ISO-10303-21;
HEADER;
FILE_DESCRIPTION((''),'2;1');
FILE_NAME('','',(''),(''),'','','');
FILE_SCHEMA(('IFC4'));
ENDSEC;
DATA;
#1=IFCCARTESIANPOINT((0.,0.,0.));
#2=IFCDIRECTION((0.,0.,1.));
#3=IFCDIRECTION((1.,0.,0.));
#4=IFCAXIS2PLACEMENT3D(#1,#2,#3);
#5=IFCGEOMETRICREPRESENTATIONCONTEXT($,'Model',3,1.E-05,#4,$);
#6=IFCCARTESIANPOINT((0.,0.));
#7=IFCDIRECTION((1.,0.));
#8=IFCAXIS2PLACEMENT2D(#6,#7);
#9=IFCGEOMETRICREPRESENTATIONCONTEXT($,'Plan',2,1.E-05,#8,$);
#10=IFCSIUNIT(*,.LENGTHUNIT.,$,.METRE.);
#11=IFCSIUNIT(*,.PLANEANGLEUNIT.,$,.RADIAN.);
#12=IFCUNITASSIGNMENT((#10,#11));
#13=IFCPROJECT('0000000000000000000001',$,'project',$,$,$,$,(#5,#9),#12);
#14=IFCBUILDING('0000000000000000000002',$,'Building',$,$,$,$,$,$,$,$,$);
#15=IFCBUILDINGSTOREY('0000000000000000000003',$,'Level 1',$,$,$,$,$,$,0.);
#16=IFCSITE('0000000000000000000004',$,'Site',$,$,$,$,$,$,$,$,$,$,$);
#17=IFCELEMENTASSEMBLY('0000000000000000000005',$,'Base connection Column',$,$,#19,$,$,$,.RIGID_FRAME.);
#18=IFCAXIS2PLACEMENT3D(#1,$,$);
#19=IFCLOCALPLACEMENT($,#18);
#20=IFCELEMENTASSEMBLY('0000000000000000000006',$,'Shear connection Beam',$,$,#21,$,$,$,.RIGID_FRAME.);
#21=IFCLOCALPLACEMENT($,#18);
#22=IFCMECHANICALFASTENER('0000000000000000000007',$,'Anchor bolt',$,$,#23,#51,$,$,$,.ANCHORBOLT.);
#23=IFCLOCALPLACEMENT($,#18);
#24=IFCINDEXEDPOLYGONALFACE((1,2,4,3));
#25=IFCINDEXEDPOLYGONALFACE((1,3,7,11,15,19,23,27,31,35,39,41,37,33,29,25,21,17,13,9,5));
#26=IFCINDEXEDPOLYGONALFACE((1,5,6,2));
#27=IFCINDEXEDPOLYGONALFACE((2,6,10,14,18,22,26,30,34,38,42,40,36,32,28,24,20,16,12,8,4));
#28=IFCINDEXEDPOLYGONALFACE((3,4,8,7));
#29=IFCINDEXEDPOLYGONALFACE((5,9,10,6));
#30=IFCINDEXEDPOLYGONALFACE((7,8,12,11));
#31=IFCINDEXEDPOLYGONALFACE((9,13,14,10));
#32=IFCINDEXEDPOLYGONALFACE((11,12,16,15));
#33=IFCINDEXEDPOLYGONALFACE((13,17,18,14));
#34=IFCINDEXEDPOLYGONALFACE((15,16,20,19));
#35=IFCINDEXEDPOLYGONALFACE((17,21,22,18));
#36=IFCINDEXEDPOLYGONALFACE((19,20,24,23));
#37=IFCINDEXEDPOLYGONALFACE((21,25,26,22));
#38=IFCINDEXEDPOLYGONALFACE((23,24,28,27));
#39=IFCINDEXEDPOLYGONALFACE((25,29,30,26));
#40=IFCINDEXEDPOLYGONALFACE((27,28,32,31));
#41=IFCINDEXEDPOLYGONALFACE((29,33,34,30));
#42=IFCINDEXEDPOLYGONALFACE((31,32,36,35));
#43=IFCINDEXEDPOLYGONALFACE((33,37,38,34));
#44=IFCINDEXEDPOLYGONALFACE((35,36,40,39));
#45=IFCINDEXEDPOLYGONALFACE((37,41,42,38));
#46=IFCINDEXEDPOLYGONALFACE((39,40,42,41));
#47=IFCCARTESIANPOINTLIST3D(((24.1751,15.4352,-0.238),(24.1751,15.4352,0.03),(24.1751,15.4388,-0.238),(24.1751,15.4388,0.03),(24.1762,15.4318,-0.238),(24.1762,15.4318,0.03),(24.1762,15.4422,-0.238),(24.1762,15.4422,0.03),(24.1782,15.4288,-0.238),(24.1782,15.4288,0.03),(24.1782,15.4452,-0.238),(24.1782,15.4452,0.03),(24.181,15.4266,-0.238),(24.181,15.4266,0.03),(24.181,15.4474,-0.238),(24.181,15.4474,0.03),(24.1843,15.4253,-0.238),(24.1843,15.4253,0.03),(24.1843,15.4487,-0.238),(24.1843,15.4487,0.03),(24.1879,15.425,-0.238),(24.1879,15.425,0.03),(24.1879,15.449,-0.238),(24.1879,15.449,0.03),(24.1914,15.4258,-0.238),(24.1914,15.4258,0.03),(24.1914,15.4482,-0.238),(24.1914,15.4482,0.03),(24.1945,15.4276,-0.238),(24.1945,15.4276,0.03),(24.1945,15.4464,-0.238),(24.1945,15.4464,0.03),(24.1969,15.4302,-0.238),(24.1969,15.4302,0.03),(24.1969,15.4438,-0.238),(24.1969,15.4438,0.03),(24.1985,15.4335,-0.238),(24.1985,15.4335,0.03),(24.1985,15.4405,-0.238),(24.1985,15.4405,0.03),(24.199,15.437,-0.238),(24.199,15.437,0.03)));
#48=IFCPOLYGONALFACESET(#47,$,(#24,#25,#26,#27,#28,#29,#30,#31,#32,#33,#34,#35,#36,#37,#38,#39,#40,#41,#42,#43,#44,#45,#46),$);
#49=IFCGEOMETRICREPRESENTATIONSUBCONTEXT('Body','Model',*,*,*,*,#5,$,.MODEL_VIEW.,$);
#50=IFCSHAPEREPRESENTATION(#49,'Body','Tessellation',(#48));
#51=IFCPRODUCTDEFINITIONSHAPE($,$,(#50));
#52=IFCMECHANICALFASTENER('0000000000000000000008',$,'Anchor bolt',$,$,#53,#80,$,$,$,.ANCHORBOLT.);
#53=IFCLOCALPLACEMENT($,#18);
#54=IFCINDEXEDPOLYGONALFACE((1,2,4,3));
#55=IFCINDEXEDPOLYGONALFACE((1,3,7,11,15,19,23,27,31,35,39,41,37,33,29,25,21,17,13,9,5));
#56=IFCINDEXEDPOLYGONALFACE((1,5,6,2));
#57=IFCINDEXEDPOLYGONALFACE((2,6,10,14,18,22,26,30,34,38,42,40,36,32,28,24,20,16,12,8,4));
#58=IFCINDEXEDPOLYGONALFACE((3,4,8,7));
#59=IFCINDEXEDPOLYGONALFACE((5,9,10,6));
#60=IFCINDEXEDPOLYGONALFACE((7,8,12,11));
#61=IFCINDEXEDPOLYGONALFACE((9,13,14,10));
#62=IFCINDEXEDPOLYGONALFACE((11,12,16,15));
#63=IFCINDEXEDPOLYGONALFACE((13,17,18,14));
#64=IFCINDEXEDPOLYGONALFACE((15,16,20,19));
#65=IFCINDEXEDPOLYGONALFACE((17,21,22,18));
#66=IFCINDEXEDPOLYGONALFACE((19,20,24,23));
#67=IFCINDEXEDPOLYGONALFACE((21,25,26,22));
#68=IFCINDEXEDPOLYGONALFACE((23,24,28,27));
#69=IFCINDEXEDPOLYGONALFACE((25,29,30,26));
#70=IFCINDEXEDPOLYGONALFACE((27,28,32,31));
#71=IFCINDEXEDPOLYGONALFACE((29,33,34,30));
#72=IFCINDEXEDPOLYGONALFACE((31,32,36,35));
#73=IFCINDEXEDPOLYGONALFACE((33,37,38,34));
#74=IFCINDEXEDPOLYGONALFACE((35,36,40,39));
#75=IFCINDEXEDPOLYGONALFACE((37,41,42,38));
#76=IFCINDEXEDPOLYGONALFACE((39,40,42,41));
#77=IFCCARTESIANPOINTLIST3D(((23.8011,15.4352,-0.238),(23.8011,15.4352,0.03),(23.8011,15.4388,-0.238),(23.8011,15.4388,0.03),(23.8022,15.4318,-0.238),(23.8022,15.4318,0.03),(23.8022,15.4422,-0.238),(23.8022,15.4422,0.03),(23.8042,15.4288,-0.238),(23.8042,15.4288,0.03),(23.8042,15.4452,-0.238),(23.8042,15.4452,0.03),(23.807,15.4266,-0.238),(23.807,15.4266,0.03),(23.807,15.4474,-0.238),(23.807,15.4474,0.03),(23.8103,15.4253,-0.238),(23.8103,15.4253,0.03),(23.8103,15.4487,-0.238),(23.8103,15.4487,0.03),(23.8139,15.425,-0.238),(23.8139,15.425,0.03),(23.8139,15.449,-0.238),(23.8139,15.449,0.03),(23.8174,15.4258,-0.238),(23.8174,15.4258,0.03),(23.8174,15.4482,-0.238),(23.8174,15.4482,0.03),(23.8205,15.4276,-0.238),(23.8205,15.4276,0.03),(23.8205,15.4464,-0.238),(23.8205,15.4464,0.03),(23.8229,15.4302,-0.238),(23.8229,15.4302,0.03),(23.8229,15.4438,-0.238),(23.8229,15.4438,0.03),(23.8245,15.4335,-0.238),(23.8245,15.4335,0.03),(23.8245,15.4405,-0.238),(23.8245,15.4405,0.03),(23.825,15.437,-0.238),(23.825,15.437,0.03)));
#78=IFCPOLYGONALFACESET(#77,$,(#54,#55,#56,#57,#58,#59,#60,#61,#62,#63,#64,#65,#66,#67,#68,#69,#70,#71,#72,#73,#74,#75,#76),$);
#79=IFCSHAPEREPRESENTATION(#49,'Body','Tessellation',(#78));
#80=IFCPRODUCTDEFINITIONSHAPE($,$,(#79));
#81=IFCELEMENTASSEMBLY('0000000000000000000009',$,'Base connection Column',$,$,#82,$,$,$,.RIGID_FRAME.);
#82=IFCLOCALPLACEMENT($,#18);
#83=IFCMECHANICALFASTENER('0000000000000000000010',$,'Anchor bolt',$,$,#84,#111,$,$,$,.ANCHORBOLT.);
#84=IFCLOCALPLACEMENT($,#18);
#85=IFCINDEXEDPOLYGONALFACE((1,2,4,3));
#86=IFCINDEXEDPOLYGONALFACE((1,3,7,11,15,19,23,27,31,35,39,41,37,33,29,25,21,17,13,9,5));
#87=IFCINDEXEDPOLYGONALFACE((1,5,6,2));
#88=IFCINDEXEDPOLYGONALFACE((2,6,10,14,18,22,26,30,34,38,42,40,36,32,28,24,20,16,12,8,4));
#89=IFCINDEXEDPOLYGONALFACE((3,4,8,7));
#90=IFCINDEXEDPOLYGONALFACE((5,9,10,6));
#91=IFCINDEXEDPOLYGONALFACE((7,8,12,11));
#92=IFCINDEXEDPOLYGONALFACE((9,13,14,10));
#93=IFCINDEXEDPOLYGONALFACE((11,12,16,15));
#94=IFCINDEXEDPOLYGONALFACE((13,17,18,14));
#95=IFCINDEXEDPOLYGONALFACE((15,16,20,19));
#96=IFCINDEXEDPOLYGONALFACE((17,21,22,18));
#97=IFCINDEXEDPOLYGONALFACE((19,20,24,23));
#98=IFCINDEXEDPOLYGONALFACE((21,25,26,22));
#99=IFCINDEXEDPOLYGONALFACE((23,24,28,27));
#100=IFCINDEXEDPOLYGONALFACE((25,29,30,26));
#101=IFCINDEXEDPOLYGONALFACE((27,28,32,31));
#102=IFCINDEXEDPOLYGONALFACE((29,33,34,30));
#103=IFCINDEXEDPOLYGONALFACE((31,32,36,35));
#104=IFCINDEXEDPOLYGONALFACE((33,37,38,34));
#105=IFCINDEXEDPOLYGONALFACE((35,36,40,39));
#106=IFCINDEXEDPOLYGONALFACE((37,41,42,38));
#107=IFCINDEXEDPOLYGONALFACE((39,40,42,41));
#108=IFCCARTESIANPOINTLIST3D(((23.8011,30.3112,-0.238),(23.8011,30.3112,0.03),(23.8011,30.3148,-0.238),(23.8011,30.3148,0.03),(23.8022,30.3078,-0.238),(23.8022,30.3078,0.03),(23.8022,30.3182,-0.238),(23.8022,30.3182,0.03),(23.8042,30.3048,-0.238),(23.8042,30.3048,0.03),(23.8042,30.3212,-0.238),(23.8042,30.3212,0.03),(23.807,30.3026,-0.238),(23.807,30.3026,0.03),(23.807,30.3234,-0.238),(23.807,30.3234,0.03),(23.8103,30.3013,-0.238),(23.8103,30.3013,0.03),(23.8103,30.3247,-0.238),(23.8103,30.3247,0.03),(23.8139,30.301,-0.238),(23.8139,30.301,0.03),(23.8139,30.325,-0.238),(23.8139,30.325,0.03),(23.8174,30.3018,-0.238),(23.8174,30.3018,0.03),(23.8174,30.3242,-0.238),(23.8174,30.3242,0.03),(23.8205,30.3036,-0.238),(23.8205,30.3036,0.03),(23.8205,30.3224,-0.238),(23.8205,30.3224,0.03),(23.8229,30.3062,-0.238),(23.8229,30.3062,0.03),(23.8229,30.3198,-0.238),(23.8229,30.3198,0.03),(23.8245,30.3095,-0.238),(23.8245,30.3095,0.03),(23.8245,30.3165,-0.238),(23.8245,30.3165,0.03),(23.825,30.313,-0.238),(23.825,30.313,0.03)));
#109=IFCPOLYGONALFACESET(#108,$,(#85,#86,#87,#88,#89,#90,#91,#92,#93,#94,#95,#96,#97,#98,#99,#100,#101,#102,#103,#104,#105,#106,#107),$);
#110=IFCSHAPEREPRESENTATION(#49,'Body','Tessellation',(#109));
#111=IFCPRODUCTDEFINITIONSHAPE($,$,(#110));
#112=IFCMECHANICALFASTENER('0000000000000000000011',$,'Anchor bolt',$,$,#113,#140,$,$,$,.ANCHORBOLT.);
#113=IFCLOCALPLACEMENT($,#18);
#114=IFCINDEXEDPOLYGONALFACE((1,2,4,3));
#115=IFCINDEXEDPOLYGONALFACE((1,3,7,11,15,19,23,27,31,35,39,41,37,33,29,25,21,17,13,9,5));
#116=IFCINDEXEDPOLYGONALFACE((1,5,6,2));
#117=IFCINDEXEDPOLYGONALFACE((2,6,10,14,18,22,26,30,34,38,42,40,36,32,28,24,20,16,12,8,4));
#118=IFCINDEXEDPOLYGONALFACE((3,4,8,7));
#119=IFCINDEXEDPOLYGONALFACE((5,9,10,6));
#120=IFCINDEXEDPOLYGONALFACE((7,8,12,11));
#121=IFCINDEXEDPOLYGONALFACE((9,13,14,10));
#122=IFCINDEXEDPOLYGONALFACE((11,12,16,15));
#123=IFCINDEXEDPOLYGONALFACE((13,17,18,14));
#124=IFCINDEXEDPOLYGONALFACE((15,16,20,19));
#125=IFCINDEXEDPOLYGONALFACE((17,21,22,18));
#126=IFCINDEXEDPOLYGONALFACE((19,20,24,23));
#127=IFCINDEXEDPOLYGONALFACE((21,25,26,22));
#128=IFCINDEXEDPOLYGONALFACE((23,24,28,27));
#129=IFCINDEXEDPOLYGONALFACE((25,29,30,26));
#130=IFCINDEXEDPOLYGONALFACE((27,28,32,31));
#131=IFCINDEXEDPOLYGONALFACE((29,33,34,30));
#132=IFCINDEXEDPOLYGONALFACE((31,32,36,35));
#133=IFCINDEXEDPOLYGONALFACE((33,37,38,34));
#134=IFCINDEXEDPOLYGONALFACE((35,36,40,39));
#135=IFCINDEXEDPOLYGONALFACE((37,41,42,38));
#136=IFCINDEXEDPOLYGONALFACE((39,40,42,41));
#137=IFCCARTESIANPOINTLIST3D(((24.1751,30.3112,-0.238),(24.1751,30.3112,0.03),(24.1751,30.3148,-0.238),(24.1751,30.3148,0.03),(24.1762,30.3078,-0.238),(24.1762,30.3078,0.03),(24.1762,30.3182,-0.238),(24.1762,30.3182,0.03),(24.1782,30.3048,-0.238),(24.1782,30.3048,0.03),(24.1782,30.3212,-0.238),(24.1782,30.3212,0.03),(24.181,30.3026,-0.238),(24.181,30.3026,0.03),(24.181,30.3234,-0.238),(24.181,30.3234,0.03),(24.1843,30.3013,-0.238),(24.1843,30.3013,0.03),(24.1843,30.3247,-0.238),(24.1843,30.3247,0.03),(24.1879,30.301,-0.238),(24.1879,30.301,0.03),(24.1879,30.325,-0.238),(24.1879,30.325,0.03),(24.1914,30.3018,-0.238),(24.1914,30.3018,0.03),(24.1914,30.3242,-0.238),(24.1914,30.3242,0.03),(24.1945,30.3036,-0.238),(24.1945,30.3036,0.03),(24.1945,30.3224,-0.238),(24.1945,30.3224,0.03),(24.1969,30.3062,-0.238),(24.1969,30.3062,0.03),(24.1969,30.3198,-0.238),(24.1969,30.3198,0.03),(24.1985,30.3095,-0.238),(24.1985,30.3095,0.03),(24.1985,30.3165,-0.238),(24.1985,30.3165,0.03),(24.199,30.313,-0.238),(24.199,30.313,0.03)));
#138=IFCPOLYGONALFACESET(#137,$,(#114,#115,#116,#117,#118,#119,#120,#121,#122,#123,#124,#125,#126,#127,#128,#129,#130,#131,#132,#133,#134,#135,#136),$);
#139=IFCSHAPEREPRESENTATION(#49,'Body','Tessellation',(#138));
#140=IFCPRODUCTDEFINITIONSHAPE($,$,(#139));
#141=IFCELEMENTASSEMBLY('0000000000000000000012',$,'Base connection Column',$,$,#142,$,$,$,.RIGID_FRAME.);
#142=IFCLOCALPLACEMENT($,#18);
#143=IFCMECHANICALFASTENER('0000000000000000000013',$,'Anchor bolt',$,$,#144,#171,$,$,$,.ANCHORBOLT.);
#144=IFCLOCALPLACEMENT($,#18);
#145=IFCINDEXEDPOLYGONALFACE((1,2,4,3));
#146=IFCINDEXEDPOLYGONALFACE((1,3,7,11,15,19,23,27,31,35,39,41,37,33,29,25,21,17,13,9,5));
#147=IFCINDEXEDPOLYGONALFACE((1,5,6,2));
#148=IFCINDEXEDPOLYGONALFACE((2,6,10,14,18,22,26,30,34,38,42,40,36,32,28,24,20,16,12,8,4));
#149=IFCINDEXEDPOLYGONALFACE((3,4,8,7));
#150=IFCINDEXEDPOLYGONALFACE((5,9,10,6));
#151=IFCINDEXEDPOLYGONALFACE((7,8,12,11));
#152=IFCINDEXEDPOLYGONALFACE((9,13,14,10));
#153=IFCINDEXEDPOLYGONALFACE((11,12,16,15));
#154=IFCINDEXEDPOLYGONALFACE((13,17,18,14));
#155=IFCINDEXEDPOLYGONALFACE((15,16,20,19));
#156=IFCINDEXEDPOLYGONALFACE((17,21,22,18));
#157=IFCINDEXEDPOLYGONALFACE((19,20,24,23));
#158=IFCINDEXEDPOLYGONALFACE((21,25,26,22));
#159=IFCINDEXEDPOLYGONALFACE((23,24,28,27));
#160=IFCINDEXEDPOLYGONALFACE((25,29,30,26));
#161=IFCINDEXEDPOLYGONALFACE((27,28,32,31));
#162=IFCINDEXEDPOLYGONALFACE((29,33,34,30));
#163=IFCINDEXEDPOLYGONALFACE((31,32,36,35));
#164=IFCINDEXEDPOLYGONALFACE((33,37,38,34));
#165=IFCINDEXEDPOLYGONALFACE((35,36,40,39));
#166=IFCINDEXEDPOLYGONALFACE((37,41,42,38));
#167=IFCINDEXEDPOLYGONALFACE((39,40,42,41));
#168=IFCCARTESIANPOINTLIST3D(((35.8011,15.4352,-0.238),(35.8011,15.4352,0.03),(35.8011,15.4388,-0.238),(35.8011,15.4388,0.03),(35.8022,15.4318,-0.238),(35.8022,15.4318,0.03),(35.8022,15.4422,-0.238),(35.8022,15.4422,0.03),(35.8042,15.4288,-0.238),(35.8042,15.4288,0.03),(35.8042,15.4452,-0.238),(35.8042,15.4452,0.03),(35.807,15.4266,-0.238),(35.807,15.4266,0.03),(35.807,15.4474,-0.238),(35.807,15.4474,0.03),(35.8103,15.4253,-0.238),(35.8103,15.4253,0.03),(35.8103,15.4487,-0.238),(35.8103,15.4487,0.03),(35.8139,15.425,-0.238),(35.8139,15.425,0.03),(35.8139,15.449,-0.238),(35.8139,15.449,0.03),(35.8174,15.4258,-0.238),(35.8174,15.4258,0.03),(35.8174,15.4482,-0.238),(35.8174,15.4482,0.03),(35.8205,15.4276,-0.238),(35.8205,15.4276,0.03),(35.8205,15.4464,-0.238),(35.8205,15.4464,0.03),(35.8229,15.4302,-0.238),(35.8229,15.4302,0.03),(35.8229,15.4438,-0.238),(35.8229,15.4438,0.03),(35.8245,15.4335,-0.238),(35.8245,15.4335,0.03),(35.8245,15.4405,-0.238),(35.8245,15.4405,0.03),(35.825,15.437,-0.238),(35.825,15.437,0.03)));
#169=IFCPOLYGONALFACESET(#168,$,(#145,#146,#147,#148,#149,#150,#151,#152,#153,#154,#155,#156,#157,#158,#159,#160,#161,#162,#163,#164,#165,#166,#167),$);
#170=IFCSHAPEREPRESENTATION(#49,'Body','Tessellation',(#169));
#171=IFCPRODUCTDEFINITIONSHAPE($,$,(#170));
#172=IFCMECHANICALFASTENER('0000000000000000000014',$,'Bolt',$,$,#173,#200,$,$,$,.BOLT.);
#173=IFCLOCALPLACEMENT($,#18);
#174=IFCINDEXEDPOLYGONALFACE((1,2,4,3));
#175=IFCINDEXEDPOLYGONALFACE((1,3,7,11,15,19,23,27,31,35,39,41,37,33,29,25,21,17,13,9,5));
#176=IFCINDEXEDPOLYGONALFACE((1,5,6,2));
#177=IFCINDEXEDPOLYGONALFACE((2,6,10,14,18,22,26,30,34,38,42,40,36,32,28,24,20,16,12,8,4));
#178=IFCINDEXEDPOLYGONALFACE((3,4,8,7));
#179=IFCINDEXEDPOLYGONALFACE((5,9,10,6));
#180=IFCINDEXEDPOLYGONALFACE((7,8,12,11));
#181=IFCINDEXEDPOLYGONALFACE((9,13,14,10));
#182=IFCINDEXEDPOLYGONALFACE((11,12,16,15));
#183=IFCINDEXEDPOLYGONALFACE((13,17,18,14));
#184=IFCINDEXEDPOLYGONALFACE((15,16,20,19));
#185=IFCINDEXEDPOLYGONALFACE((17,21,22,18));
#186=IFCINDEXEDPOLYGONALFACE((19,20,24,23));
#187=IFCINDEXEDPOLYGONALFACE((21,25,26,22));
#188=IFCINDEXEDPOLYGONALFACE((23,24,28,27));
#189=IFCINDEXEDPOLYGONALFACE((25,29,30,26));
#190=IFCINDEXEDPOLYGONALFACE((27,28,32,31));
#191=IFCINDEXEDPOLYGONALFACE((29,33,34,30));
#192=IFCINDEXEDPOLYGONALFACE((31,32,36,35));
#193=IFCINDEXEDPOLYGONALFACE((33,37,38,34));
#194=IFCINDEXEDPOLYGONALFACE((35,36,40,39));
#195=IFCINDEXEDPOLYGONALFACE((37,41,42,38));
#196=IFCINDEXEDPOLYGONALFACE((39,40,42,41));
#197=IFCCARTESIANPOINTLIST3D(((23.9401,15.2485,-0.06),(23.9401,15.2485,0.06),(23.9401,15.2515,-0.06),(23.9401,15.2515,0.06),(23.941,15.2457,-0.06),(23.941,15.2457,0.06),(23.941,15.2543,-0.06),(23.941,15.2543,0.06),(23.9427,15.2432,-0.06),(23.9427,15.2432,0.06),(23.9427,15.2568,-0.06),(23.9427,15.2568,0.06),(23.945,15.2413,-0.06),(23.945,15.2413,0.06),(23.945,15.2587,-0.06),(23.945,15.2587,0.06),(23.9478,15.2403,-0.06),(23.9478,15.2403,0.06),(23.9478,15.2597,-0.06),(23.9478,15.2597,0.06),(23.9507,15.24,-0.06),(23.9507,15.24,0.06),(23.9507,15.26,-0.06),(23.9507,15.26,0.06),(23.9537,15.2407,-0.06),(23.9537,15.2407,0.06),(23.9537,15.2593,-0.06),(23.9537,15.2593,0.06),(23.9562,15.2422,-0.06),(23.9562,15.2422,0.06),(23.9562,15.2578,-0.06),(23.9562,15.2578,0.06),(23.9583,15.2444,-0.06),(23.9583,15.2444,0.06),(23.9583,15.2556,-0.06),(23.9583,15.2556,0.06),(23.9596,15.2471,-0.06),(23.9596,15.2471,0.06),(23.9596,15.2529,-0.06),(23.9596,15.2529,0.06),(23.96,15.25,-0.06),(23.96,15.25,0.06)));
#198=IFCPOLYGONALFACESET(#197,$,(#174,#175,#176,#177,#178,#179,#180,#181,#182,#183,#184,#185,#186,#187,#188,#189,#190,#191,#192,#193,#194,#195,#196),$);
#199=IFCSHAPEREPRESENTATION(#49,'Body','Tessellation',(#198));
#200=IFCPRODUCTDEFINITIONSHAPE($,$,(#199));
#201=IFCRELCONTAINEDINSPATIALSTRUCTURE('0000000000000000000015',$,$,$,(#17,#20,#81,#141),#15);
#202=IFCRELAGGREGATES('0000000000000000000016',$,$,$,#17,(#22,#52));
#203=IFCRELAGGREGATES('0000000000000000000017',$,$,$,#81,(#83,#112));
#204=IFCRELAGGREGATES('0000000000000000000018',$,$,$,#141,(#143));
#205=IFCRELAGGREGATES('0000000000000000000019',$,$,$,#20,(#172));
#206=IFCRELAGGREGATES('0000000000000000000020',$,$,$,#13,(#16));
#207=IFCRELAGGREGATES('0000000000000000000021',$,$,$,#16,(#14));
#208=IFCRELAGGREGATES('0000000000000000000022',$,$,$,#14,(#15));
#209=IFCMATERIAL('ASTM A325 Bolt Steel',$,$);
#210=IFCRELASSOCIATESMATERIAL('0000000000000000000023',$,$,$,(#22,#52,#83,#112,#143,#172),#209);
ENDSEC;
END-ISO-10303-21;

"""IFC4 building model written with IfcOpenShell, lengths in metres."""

from ifc_helpers import new_model, si_unit, frame, origin_with_axes, origin_2d, origin_2d_with_axis, place, context, subcontext, project, spatial, circle, extrude, material, element, aggregate, save


model = new_model("IFC4")

# Units and contexts
model_context = context("Model", 3, precision=1e-05, world=origin_with_axes())
plan_context = context("Plan", 2, precision=1e-05, world=origin_2d_with_axis())
body_context = subcontext(model_context, "Body", "Model", "MODEL_VIEW")
ifc_project = project(units=[si_unit("LENGTHUNIT", "METRE"), si_unit("PLANEANGLEUNIT", "RADIAN")], contexts=[model_context, plan_context])

# Site, building, storey
site = spatial("IfcSite", under=ifc_project, Name="Site")
building = spatial("IfcBuilding", under=site, Name="Building")
storey = spatial("IfcBuildingStorey", under=building, Name="Level 1", Elevation=0.0)

# Element assembly
assembly_1 = element("IfcElementAssembly", 1, inside=storey, Name="Base connection Column", PredefinedType="RIGID_FRAME")

# Element assembly
assembly_2 = element("IfcElementAssembly", 2, inside=storey, Name="Shear connection Beam", PredefinedType="RIGID_FRAME")

# Mechanical fasteners
ifc_material_1 = material(Name="ASTM A325 Bolt Steel")
mechanical_fastener_1_placement = place(None, frame((24.187, 15.437, -0.238), z_axis=(0.0, 0.0, 1.0), x_axis=(1.0, 0.0, 0.0)))
mechanical_fastener_1 = element("IfcMechanicalFastener", 3, at=mechanical_fastener_1_placement, material=ifc_material_1, Name="Anchor bolt", PredefinedType="ANCHORBOLT", context=body_context, shape_type="SweptSolid", body=[
    extrude(circle(Radius=0.012, at=origin_2d()), origin_with_axes(), (0.0, 0.0, 1.0), 0.268),
])
mechanical_fastener_2_placement = place(None, frame((23.813, 15.437, -0.238), z_axis=(0.0, 0.0, 1.0), x_axis=(1.0, 0.0, 0.0)))
mechanical_fastener_2 = element("IfcMechanicalFastener", 4, at=mechanical_fastener_2_placement, material=ifc_material_1, Name="Anchor bolt", PredefinedType="ANCHORBOLT", context=body_context, shape_type="SweptSolid", body=[
    extrude(circle(Radius=0.012, at=origin_2d()), origin_with_axes(), (0.0, 0.0, 1.0), 0.268),
])
aggregate(assembly_1, [mechanical_fastener_1, mechanical_fastener_2])

# Element assembly, mechanical fasteners
assembly_3 = element("IfcElementAssembly", 5, inside=storey, Name="Base connection Column", PredefinedType="RIGID_FRAME")
mechanical_fastener_3_placement = place(None, frame((23.813, 30.313, -0.238), z_axis=(0.0, 0.0, 1.0), x_axis=(1.0, 0.0, 0.0)))
mechanical_fastener_3 = element("IfcMechanicalFastener", 6, at=mechanical_fastener_3_placement, material=ifc_material_1, Name="Anchor bolt", PredefinedType="ANCHORBOLT", context=body_context, shape_type="SweptSolid", body=[
    extrude(circle(Radius=0.012, at=origin_2d()), origin_with_axes(), (0.0, 0.0, 1.0), 0.268),
])
mechanical_fastener_4_placement = place(None, frame((24.187, 30.313, -0.238), z_axis=(0.0, 0.0, 1.0), x_axis=(1.0, 0.0, 0.0)))
mechanical_fastener_4 = element("IfcMechanicalFastener", 7, at=mechanical_fastener_4_placement, material=ifc_material_1, Name="Anchor bolt", PredefinedType="ANCHORBOLT", context=body_context, shape_type="SweptSolid", body=[
    extrude(circle(Radius=0.012, at=origin_2d()), origin_with_axes(), (0.0, 0.0, 1.0), 0.268),
])
aggregate(assembly_3, [mechanical_fastener_3, mechanical_fastener_4])

# Element assembly, mechanical fastener
assembly_4 = element("IfcElementAssembly", 8, inside=storey, Name="Base connection Column", PredefinedType="RIGID_FRAME")
mechanical_fastener_5_placement = place(None, frame((35.813, 15.437, -0.238), z_axis=(0.0, 0.0, 1.0), x_axis=(1.0, 0.0, 0.0)))
mechanical_fastener_5 = element("IfcMechanicalFastener", 9, at=mechanical_fastener_5_placement, material=ifc_material_1, Name="Anchor bolt", PredefinedType="ANCHORBOLT", context=body_context, shape_type="SweptSolid", body=[
    extrude(circle(Radius=0.012, at=origin_2d()), origin_with_axes(), (0.0, 0.0, 1.0), 0.268),
])
aggregate(assembly_4, [mechanical_fastener_5])

# Mechanical fastener
mechanical_fastener_6_placement = place(None, frame((23.95, 15.25, -0.06), z_axis=(0.0, 0.0, 1.0), x_axis=(1.0, 0.0, 0.0)))
mechanical_fastener_6 = element("IfcMechanicalFastener", 10, at=mechanical_fastener_6_placement, material=ifc_material_1, Name="Bolt", PredefinedType="BOLT", context=body_context, shape_type="SweptSolid", body=[
    extrude(circle(Radius=0.01, at=origin_2d()), origin_with_axes(), (0.0, 0.0, 1.0), 0.12),
])
aggregate(assembly_2, [mechanical_fastener_6])

save(model, "model.ifc")
